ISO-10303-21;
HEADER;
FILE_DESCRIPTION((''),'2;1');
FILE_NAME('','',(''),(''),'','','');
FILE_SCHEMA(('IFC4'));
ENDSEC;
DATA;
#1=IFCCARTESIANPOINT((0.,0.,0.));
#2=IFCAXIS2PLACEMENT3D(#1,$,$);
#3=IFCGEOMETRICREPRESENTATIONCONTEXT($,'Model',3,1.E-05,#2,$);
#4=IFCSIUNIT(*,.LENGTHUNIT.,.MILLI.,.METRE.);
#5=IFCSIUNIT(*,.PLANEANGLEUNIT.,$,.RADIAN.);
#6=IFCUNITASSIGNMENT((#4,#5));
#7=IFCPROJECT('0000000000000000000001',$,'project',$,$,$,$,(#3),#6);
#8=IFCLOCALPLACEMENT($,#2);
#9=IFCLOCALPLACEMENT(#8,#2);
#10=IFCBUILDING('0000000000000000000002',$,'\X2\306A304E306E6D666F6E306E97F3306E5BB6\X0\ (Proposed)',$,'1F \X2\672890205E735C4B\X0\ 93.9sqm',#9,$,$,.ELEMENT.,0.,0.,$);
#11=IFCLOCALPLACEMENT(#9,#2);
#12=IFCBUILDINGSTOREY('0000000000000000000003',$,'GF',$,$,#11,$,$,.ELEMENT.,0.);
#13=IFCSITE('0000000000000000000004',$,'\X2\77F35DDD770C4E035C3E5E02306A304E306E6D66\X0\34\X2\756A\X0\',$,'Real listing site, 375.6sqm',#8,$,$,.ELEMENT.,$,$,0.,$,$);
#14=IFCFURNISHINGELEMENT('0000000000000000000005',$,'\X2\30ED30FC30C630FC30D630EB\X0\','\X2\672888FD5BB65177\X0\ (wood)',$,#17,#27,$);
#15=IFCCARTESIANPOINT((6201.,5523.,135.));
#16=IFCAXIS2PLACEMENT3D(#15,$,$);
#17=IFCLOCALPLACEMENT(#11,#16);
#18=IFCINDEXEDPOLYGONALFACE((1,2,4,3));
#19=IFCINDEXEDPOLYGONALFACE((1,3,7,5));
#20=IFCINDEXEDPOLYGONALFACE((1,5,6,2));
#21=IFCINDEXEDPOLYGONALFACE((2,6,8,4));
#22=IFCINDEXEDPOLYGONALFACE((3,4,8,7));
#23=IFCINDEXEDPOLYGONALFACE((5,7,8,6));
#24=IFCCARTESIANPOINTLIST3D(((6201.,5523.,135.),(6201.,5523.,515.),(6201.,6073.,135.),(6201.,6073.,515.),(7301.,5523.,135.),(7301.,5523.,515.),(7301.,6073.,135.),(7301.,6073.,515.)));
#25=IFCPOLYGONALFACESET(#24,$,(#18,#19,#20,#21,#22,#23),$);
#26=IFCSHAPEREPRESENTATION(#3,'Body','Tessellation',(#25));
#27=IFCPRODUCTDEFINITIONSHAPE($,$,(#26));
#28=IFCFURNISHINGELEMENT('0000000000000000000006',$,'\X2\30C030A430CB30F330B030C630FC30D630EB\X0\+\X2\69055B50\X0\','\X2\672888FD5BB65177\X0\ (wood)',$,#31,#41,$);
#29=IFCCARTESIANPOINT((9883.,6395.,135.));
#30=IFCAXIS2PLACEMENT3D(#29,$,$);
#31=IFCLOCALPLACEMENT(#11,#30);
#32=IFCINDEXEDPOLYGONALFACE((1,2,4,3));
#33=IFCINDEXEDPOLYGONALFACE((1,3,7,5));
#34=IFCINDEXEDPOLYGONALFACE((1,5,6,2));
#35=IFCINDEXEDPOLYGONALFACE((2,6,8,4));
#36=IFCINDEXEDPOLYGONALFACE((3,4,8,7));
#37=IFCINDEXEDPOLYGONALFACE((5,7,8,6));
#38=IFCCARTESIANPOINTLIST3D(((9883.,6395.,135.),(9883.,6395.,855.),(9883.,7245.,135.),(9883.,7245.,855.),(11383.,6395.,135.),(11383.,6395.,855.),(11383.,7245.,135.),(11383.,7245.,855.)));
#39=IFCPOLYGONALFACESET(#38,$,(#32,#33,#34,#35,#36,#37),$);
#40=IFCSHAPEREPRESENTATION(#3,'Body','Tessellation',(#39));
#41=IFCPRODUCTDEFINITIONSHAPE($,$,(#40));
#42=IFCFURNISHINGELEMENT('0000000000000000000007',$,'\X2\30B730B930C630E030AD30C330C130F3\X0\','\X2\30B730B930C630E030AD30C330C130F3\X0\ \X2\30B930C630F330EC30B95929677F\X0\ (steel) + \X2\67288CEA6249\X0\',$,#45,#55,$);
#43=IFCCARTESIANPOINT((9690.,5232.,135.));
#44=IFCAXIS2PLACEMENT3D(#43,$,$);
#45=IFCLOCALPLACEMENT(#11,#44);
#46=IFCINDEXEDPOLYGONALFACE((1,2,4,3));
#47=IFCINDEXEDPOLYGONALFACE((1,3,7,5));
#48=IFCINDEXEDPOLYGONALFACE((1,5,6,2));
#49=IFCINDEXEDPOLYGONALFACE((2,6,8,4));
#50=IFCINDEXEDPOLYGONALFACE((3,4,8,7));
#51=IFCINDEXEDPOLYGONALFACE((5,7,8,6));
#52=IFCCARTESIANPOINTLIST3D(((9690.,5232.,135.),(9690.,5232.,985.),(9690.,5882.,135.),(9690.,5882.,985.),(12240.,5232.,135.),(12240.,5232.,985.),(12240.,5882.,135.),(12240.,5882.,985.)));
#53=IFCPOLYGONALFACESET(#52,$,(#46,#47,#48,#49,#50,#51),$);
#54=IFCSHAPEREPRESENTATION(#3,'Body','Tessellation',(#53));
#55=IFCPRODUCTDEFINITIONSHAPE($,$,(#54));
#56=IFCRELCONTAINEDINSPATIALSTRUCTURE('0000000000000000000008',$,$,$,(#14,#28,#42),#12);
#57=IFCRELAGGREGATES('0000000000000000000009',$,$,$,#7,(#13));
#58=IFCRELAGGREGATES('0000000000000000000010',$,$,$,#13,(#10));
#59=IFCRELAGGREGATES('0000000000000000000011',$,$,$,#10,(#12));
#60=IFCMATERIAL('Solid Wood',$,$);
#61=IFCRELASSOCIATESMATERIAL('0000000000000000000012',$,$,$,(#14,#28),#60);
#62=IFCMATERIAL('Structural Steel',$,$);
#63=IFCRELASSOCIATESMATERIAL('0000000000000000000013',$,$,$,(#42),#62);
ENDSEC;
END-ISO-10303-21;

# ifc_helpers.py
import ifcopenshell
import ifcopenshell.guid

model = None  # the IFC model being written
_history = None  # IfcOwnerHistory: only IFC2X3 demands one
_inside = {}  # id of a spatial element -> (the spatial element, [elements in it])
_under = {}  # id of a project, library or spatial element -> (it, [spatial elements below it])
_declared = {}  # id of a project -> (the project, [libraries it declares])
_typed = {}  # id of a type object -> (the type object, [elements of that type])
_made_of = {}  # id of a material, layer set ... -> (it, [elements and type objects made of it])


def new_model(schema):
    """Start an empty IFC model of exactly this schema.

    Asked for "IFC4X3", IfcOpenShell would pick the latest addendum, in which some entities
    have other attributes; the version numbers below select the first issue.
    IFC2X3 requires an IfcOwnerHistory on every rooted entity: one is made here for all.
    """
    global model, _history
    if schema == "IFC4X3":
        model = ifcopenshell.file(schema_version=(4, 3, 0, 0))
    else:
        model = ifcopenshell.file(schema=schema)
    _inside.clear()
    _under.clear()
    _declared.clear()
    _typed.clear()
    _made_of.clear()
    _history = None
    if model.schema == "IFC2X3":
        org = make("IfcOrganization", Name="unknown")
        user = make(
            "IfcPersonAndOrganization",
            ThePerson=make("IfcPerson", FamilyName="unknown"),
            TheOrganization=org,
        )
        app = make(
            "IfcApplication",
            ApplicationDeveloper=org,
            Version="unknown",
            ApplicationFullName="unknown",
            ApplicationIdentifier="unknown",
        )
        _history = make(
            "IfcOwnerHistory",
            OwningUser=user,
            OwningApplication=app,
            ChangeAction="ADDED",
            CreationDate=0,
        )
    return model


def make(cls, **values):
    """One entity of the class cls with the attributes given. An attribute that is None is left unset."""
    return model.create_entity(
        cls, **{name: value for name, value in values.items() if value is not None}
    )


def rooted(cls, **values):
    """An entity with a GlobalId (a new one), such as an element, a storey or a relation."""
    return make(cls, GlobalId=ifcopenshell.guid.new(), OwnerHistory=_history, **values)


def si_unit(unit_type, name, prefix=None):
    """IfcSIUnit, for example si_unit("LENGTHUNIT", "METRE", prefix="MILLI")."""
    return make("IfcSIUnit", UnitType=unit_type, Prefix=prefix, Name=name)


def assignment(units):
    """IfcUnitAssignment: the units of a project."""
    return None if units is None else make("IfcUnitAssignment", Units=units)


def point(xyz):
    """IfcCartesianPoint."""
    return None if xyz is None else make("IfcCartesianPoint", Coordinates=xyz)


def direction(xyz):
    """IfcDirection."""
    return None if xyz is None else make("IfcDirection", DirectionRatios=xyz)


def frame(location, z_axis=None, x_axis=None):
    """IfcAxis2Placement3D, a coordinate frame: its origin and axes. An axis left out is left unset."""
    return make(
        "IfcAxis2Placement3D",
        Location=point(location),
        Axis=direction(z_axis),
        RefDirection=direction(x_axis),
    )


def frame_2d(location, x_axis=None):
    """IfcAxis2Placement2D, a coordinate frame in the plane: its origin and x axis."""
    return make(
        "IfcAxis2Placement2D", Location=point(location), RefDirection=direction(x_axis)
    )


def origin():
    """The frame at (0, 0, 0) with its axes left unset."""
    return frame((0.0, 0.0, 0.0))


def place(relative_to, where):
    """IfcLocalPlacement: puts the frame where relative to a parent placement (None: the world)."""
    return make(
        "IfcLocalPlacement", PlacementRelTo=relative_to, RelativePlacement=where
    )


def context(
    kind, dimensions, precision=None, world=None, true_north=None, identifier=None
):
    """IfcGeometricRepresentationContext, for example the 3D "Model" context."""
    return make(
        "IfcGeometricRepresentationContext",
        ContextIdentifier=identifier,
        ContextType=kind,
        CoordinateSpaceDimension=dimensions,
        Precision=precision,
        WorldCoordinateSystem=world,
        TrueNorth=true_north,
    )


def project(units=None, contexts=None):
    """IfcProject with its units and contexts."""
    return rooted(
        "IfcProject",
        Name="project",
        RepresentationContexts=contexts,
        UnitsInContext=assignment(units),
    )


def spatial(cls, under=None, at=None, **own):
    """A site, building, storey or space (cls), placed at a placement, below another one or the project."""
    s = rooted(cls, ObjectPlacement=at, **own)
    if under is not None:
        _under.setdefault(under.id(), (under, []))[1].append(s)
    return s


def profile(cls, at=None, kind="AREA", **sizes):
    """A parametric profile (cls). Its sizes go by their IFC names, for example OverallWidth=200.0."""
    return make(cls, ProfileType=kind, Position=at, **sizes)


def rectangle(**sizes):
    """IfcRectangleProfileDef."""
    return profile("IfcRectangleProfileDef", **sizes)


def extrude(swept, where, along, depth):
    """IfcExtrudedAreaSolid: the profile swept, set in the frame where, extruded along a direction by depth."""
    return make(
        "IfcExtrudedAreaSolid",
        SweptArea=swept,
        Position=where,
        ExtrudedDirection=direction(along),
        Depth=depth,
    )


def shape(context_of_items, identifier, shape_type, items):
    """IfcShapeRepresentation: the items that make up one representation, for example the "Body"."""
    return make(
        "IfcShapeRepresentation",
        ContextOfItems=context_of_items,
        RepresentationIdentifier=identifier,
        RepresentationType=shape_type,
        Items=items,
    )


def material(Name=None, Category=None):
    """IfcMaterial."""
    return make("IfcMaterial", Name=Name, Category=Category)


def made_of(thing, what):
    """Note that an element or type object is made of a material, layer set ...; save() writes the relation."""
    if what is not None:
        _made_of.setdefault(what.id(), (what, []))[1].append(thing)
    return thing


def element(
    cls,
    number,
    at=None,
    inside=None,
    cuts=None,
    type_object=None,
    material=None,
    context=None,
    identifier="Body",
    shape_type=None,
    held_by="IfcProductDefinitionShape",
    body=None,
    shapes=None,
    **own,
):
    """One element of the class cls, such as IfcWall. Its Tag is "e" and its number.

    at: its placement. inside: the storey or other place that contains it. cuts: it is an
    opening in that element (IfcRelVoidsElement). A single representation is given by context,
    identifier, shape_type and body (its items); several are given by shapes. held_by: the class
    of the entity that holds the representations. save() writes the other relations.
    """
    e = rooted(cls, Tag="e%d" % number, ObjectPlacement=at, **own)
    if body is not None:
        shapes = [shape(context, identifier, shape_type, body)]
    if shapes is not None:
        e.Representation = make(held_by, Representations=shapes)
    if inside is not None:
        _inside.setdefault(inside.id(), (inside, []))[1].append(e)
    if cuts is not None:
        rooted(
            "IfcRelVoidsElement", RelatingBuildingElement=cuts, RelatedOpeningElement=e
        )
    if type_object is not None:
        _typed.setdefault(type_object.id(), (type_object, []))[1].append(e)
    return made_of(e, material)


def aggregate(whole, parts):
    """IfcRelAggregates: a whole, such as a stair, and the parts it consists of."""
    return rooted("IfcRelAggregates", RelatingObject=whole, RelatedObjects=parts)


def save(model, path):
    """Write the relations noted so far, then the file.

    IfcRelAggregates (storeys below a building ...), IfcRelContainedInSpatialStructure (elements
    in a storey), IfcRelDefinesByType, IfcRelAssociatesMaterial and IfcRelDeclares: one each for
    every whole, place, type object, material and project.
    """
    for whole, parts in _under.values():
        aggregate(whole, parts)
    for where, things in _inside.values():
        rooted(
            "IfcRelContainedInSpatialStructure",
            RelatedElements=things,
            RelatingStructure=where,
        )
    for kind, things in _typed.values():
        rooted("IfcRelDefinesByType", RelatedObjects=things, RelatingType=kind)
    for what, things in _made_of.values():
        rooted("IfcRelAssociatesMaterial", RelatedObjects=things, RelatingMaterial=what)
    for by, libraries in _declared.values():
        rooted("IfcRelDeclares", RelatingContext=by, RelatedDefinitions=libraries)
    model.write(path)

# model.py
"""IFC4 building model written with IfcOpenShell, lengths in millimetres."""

from ifc_helpers import new_model, si_unit, frame, frame_2d, origin, place, context, project, spatial, rectangle, extrude, material, element, save


model = new_model("IFC4")

# Units and contexts
model_context = context("Model", 3, precision=1e-05, world=origin())
ifc_project = project(units=[si_unit("LENGTHUNIT", "METRE", prefix="MILLI"), si_unit("PLANEANGLEUNIT", "RADIAN")], contexts=[model_context])

# Site, building, storey
site_placement = place(None, origin())
site = spatial("IfcSite", under=ifc_project, at=site_placement, Name="石川県七尾市なぎの浦34番", ObjectType="Real listing site, 375.6sqm", CompositionType="ELEMENT", RefElevation=0.0)
building_placement = place(site_placement, origin())
building = spatial("IfcBuilding", under=site, at=building_placement, Name="なぎの浦潮の音の家 (Proposed)", ObjectType="1F 木造平屋 93.9sqm", CompositionType="ELEMENT", ElevationOfRefHeight=0.0, ElevationOfTerrain=0.0)
storey_placement = place(building_placement, origin())
storey = spatial("IfcBuildingStorey", under=building, at=storey_placement, Name="GF", CompositionType="ELEMENT", Elevation=0.0)

# Shared definitions
ifc_material_1 = material(Name="Solid Wood")

# Shared definitions
ifc_material_2 = material(Name="Structural Steel")

# Furnishing elements
furnishing_1_placement = place(storey_placement, frame((6201.0, 5523.0, 135.0)))
element("IfcFurnishingElement", 1, at=furnishing_1_placement, inside=storey, material=ifc_material_1, Name="ローテーブル", Description="木製家具 (wood)", context=model_context, shape_type="SweptSolid", body=[
    extrude(rectangle(XDim=1100.0, YDim=550.0, at=frame_2d((550.0, 275.0))), frame((6201.0, 5523.0, 135.0)), (0.0, 0.0, 1.0), 380.0),
])
furnishing_2_placement = place(storey_placement, frame((9883.0, 6395.0, 135.0)))
element("IfcFurnishingElement", 2, at=furnishing_2_placement, inside=storey, material=ifc_material_1, Name="ダイニングテーブル+椅子", Description="木製家具 (wood)", context=model_context, shape_type="SweptSolid", body=[
    extrude(rectangle(XDim=1500.0, YDim=850.0, at=frame_2d((750.0, 425.0))), frame((9883.0, 6395.0, 135.0)), (0.0, 0.0, 1.0), 720.0),
])
furnishing_3_placement = place(storey_placement, frame((9690.0, 5232.0, 135.0)))
element("IfcFurnishingElement", 3, at=furnishing_3_placement, inside=storey, material=ifc_material_2, Name="システムキッチン", Description="システムキッチン ステンレス天板 (steel) + 木質扉", context=model_context, shape_type="SweptSolid", body=[
    extrude(rectangle(XDim=2550.0, YDim=650.0, at=frame_2d((1275.0, 325.0))), frame((9690.0, 5232.0, 135.0)), (0.0, 0.0, 1.0), 850.0),
])

save(model, "model.ifc")
